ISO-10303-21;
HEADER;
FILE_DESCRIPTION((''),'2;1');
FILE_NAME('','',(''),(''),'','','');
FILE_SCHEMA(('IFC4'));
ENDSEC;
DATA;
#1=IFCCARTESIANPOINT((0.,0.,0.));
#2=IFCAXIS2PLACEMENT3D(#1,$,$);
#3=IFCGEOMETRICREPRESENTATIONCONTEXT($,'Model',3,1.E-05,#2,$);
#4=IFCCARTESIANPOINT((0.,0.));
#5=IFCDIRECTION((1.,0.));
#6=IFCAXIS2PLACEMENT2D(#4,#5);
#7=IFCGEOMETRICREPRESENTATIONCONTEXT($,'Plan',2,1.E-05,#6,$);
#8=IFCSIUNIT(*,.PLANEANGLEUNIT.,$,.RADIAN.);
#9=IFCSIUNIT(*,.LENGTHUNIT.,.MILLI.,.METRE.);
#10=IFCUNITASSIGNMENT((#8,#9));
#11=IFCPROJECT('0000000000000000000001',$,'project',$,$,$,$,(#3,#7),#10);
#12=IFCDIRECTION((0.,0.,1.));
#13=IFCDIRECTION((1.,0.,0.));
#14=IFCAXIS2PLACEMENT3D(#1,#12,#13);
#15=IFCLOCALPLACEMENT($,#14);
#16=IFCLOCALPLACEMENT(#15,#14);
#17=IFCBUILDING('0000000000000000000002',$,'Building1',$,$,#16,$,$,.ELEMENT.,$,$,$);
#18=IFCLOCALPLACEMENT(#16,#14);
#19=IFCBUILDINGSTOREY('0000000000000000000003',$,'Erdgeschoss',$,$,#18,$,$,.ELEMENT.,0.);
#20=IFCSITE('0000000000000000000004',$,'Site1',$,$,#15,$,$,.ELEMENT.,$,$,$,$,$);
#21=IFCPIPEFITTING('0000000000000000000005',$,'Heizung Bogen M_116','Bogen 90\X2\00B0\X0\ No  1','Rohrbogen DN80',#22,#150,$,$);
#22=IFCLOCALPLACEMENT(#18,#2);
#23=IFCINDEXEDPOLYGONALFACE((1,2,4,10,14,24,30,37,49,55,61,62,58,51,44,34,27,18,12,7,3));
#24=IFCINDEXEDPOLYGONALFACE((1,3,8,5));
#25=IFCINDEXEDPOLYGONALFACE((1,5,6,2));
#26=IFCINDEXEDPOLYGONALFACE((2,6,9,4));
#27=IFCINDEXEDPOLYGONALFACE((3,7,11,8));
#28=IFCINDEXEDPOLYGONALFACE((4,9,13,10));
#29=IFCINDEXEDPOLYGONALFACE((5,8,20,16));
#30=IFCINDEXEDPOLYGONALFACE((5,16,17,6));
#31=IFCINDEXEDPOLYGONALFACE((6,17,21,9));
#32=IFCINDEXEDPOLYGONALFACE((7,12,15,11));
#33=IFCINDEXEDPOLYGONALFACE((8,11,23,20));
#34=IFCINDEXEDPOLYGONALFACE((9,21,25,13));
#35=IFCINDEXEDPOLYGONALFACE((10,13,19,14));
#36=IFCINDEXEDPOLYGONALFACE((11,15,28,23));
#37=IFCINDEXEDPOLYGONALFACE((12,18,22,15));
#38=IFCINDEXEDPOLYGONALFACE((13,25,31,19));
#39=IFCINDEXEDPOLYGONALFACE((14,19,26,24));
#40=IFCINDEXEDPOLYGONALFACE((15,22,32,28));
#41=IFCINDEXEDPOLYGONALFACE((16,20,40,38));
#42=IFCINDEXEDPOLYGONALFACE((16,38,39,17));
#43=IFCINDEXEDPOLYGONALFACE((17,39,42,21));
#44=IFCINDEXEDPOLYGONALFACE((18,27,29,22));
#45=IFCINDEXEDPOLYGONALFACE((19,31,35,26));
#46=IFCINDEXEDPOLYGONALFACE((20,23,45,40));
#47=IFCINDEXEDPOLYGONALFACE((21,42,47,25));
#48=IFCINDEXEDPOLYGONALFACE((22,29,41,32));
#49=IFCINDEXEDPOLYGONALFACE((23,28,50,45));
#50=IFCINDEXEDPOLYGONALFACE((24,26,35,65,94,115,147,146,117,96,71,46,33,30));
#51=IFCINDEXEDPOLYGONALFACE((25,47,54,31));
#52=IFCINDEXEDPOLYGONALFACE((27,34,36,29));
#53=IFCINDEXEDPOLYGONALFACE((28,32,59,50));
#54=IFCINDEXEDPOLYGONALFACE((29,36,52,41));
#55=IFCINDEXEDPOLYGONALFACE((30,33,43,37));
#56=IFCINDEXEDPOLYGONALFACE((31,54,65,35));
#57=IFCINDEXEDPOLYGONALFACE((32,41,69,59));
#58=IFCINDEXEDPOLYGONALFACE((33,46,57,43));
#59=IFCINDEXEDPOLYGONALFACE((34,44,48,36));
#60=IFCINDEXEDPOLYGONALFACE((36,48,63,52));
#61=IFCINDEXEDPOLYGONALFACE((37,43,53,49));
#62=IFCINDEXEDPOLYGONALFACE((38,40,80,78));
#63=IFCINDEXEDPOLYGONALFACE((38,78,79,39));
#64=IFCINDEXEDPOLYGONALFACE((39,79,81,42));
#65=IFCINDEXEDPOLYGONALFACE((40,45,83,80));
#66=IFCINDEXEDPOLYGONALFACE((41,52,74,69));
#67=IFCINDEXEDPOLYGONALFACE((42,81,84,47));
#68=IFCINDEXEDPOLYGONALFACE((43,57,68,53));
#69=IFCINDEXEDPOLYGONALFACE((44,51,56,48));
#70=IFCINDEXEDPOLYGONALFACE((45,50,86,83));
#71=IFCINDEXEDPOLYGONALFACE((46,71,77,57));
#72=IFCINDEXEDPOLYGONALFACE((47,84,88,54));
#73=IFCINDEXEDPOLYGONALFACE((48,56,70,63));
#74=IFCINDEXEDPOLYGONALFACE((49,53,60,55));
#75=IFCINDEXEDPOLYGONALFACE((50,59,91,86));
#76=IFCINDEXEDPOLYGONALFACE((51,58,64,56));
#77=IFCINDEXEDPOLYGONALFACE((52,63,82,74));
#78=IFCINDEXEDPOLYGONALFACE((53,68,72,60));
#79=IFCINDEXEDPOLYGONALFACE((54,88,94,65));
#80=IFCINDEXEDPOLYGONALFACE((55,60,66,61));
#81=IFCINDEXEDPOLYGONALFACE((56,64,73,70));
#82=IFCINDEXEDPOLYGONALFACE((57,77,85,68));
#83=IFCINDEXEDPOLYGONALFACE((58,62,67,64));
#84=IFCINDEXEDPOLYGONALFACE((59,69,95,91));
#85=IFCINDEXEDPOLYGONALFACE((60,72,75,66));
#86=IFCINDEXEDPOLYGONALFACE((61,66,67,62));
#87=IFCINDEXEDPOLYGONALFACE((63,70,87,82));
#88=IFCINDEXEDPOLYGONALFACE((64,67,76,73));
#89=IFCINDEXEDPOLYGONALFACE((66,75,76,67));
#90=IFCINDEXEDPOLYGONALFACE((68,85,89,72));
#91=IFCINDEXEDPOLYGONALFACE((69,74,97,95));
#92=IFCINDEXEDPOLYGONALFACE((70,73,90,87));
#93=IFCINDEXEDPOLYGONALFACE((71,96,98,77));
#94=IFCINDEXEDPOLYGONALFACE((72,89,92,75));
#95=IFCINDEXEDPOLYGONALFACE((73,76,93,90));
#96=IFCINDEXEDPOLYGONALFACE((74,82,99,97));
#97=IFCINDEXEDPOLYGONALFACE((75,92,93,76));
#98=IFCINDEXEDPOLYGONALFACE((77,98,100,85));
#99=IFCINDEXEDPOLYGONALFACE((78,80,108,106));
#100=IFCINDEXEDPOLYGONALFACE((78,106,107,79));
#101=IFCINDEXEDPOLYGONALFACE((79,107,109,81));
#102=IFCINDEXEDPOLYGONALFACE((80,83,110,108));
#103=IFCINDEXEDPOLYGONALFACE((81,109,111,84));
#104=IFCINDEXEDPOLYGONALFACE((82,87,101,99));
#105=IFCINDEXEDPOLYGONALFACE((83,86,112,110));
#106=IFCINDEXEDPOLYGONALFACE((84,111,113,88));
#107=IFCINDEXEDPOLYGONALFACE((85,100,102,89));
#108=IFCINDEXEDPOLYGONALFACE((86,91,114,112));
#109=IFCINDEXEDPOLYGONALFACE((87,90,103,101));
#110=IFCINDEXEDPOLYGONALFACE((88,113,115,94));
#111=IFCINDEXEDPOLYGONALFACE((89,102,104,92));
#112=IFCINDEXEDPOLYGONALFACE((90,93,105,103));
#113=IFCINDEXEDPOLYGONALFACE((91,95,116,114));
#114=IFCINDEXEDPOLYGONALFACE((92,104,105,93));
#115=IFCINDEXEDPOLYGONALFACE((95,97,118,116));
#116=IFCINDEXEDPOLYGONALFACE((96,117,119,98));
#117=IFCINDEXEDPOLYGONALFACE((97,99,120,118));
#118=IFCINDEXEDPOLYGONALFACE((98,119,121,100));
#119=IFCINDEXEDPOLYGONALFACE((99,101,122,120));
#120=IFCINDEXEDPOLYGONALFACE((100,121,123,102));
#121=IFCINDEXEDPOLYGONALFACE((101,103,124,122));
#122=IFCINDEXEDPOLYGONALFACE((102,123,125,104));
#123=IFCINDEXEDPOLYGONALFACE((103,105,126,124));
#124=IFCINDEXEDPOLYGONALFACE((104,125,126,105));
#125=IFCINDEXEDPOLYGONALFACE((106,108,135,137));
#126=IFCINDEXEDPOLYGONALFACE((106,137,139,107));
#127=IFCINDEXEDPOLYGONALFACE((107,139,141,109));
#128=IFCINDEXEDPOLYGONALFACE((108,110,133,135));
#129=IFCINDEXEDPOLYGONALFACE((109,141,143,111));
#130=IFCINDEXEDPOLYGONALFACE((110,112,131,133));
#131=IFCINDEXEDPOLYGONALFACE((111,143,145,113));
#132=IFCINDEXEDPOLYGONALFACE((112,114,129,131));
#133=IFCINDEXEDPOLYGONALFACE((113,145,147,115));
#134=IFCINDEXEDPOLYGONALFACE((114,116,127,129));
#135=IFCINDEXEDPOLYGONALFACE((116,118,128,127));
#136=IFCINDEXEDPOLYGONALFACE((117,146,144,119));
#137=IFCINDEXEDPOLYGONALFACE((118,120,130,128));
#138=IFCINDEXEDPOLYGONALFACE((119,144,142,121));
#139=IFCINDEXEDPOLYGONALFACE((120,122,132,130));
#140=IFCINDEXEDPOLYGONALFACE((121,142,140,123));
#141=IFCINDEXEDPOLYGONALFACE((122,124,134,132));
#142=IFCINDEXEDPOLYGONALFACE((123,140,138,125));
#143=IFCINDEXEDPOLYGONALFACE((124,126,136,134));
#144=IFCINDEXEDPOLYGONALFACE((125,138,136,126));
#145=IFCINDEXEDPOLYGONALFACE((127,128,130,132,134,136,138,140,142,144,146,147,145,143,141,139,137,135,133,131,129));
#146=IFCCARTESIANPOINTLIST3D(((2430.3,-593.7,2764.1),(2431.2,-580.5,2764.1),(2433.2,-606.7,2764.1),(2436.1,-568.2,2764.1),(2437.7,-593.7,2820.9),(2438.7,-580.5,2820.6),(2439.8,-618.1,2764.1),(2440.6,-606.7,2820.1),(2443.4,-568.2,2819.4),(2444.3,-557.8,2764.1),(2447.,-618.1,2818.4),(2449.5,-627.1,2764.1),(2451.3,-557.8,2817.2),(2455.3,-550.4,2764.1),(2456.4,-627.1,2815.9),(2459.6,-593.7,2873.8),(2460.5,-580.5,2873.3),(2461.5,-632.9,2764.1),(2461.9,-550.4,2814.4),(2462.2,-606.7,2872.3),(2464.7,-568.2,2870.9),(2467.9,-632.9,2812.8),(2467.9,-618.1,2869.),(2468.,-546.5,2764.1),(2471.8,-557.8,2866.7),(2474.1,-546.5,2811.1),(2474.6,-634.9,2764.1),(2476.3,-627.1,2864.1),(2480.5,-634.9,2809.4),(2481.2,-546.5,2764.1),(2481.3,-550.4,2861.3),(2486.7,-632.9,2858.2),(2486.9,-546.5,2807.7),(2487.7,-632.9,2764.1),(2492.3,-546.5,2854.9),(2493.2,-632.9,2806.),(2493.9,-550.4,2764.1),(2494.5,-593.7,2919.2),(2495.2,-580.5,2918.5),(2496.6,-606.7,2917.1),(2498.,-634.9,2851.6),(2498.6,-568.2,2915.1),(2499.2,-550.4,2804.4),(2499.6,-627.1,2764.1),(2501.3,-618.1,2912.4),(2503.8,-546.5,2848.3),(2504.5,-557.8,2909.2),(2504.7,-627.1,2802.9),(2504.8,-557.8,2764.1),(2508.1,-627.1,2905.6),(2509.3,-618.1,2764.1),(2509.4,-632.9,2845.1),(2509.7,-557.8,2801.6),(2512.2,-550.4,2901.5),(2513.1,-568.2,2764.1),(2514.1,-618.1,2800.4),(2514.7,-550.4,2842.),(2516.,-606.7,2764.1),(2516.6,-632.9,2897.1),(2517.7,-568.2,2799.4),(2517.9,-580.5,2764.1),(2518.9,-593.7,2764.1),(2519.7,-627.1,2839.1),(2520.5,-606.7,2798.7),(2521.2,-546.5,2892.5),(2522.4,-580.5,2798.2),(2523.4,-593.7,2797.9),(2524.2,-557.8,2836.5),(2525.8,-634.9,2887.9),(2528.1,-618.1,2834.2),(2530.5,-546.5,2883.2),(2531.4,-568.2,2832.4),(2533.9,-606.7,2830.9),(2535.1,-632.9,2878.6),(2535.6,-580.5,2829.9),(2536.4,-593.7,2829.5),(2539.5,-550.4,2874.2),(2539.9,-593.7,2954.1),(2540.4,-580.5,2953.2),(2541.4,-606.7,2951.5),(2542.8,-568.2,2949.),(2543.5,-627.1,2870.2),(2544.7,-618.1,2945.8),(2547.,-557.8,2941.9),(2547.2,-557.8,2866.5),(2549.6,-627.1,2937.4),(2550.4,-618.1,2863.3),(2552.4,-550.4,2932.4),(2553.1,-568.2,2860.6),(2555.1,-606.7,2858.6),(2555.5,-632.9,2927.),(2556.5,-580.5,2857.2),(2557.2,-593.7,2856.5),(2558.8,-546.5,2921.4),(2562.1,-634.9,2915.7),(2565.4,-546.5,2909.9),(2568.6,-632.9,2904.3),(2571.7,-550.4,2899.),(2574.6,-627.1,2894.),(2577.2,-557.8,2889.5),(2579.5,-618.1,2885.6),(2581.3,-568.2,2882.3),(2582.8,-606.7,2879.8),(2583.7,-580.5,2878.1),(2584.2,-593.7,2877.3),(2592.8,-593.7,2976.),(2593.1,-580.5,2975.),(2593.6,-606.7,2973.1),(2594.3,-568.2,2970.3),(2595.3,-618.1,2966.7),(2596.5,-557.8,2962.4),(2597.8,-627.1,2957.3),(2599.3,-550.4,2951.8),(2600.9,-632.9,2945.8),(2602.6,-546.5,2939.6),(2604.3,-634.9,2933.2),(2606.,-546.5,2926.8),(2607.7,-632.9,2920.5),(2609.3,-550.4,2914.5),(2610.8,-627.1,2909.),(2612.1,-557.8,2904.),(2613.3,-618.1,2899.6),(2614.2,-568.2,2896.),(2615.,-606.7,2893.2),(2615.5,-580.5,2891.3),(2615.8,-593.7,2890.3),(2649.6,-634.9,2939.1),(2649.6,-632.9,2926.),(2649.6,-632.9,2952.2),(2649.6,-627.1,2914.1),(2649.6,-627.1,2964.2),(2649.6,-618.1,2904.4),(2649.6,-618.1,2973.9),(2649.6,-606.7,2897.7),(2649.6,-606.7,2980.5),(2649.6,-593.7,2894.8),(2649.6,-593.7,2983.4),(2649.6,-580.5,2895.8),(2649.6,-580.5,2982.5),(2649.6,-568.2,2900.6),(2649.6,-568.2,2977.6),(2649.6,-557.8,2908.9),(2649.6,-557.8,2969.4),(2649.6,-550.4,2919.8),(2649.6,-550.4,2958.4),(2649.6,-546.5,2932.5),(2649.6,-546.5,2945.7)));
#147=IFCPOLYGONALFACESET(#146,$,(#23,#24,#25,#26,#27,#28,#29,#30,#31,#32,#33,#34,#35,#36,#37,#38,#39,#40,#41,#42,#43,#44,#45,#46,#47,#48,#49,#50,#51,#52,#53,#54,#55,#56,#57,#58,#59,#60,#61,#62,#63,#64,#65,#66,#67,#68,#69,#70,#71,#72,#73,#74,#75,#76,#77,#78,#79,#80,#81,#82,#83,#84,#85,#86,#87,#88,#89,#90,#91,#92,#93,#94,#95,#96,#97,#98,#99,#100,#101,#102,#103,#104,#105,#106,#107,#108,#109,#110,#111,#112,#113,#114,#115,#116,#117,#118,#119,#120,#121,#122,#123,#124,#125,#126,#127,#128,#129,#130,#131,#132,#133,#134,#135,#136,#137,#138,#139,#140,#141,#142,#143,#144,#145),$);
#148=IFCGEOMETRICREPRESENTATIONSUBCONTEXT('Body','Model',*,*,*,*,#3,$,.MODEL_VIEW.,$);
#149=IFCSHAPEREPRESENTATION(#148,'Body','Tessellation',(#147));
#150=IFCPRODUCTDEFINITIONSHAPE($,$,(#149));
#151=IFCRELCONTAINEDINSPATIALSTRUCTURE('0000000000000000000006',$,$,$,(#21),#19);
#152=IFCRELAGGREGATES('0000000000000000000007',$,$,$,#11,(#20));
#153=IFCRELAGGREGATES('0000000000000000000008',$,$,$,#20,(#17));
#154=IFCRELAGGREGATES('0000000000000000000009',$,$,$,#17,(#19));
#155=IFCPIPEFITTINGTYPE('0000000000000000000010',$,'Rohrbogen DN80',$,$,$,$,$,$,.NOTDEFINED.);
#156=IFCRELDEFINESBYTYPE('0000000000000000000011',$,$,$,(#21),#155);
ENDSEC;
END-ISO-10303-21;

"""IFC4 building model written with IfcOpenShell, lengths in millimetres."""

from ifc_helpers import new_model, entity, si_unit, frame, origin, origin_with_axes, origin_2d_with_axis, place, context, subcontext, project, spatial, source, transform, mapped, type_object, element, save


model = new_model("IFC4")

# Units and contexts
model_context = context("Model", 3, precision=1e-05, world=origin())
plan_context = context("Plan", 2, precision=1e-05, world=origin_2d_with_axis())
body_context = subcontext(model_context, "Body", "Model", "MODEL_VIEW")
ifc_project = project(units=[si_unit("PLANEANGLEUNIT", "RADIAN"), si_unit("LENGTHUNIT", "METRE", prefix="MILLI")], contexts=[model_context, plan_context])

# Site, building, storey
site_placement = place(None, origin_with_axes())
site = spatial("IfcSite", under=ifc_project, at=site_placement, Name="Site1", CompositionType="ELEMENT")
building_placement = place(site_placement, origin_with_axes())
building = spatial("IfcBuilding", under=site, at=building_placement, Name="Building1", CompositionType="ELEMENT")
storey_placement = place(building_placement, origin_with_axes())
storey = spatial("IfcBuildingStorey", under=building, at=storey_placement, Name="Erdgeschoss", CompositionType="ELEMENT", Elevation=0.0)

# Pipe fitting
pipe_fitting_type_1 = type_object("IfcPipeFittingType", Name="Rohrbogen DN80", PredefinedType="NOTDEFINED")
ifc_direction_1 = entity("IfcDirection", [-1.0, 0.0, 0.0])
shared_shape_1 = source(origin_with_axes(), body_context, "Body", "SolidModel", [
    entity("IfcRevolvedAreaSolid", entity("IfcCircleProfileDef", "AREA", None, entity("IfcAxis2Placement2D", entity("IfcCartesianPoint", [0.0, 0.0]), entity("IfcDirection", [1.0, 0.0])), 44.5), entity("IfcAxis2Placement3D", entity("IfcCartesianPoint", [109.7, -65.3, 0.0]), ifc_direction_1, entity("IfcDirection", [0.0, 0.0, 1.0])), entity("IfcAxis1Placement", entity("IfcCartesianPoint", [0.0, 175.0, 0.0]), ifc_direction_1), 1.570796),
])
pipe_fitting_1_placement = place(storey_placement, frame((2539.9, -590.4, 2873.8), z_axis=(0.0, 0.0, 1.0), x_axis=(1.0, 0.0, 0.0)))
element("IfcPipeFitting", 1, at=pipe_fitting_1_placement, inside=storey, type_object=pipe_fitting_type_1, Name="Heizung Bogen M_116", Description="Bogen 90° No  1", ObjectType="Rohrbogen DN80", context=body_context, shape_type="MappedRepresentation", body=[
    mapped(shared_shape_1, transform((0.0, 0.0, 0.0), x_axis=(0.0, 0.0, -1.0), y_axis=(1.0, 0.0, 0.0), z_axis=(0.0, -1.0, 0.0), scale=1.0)),
])

save(model, "model.ifc")
